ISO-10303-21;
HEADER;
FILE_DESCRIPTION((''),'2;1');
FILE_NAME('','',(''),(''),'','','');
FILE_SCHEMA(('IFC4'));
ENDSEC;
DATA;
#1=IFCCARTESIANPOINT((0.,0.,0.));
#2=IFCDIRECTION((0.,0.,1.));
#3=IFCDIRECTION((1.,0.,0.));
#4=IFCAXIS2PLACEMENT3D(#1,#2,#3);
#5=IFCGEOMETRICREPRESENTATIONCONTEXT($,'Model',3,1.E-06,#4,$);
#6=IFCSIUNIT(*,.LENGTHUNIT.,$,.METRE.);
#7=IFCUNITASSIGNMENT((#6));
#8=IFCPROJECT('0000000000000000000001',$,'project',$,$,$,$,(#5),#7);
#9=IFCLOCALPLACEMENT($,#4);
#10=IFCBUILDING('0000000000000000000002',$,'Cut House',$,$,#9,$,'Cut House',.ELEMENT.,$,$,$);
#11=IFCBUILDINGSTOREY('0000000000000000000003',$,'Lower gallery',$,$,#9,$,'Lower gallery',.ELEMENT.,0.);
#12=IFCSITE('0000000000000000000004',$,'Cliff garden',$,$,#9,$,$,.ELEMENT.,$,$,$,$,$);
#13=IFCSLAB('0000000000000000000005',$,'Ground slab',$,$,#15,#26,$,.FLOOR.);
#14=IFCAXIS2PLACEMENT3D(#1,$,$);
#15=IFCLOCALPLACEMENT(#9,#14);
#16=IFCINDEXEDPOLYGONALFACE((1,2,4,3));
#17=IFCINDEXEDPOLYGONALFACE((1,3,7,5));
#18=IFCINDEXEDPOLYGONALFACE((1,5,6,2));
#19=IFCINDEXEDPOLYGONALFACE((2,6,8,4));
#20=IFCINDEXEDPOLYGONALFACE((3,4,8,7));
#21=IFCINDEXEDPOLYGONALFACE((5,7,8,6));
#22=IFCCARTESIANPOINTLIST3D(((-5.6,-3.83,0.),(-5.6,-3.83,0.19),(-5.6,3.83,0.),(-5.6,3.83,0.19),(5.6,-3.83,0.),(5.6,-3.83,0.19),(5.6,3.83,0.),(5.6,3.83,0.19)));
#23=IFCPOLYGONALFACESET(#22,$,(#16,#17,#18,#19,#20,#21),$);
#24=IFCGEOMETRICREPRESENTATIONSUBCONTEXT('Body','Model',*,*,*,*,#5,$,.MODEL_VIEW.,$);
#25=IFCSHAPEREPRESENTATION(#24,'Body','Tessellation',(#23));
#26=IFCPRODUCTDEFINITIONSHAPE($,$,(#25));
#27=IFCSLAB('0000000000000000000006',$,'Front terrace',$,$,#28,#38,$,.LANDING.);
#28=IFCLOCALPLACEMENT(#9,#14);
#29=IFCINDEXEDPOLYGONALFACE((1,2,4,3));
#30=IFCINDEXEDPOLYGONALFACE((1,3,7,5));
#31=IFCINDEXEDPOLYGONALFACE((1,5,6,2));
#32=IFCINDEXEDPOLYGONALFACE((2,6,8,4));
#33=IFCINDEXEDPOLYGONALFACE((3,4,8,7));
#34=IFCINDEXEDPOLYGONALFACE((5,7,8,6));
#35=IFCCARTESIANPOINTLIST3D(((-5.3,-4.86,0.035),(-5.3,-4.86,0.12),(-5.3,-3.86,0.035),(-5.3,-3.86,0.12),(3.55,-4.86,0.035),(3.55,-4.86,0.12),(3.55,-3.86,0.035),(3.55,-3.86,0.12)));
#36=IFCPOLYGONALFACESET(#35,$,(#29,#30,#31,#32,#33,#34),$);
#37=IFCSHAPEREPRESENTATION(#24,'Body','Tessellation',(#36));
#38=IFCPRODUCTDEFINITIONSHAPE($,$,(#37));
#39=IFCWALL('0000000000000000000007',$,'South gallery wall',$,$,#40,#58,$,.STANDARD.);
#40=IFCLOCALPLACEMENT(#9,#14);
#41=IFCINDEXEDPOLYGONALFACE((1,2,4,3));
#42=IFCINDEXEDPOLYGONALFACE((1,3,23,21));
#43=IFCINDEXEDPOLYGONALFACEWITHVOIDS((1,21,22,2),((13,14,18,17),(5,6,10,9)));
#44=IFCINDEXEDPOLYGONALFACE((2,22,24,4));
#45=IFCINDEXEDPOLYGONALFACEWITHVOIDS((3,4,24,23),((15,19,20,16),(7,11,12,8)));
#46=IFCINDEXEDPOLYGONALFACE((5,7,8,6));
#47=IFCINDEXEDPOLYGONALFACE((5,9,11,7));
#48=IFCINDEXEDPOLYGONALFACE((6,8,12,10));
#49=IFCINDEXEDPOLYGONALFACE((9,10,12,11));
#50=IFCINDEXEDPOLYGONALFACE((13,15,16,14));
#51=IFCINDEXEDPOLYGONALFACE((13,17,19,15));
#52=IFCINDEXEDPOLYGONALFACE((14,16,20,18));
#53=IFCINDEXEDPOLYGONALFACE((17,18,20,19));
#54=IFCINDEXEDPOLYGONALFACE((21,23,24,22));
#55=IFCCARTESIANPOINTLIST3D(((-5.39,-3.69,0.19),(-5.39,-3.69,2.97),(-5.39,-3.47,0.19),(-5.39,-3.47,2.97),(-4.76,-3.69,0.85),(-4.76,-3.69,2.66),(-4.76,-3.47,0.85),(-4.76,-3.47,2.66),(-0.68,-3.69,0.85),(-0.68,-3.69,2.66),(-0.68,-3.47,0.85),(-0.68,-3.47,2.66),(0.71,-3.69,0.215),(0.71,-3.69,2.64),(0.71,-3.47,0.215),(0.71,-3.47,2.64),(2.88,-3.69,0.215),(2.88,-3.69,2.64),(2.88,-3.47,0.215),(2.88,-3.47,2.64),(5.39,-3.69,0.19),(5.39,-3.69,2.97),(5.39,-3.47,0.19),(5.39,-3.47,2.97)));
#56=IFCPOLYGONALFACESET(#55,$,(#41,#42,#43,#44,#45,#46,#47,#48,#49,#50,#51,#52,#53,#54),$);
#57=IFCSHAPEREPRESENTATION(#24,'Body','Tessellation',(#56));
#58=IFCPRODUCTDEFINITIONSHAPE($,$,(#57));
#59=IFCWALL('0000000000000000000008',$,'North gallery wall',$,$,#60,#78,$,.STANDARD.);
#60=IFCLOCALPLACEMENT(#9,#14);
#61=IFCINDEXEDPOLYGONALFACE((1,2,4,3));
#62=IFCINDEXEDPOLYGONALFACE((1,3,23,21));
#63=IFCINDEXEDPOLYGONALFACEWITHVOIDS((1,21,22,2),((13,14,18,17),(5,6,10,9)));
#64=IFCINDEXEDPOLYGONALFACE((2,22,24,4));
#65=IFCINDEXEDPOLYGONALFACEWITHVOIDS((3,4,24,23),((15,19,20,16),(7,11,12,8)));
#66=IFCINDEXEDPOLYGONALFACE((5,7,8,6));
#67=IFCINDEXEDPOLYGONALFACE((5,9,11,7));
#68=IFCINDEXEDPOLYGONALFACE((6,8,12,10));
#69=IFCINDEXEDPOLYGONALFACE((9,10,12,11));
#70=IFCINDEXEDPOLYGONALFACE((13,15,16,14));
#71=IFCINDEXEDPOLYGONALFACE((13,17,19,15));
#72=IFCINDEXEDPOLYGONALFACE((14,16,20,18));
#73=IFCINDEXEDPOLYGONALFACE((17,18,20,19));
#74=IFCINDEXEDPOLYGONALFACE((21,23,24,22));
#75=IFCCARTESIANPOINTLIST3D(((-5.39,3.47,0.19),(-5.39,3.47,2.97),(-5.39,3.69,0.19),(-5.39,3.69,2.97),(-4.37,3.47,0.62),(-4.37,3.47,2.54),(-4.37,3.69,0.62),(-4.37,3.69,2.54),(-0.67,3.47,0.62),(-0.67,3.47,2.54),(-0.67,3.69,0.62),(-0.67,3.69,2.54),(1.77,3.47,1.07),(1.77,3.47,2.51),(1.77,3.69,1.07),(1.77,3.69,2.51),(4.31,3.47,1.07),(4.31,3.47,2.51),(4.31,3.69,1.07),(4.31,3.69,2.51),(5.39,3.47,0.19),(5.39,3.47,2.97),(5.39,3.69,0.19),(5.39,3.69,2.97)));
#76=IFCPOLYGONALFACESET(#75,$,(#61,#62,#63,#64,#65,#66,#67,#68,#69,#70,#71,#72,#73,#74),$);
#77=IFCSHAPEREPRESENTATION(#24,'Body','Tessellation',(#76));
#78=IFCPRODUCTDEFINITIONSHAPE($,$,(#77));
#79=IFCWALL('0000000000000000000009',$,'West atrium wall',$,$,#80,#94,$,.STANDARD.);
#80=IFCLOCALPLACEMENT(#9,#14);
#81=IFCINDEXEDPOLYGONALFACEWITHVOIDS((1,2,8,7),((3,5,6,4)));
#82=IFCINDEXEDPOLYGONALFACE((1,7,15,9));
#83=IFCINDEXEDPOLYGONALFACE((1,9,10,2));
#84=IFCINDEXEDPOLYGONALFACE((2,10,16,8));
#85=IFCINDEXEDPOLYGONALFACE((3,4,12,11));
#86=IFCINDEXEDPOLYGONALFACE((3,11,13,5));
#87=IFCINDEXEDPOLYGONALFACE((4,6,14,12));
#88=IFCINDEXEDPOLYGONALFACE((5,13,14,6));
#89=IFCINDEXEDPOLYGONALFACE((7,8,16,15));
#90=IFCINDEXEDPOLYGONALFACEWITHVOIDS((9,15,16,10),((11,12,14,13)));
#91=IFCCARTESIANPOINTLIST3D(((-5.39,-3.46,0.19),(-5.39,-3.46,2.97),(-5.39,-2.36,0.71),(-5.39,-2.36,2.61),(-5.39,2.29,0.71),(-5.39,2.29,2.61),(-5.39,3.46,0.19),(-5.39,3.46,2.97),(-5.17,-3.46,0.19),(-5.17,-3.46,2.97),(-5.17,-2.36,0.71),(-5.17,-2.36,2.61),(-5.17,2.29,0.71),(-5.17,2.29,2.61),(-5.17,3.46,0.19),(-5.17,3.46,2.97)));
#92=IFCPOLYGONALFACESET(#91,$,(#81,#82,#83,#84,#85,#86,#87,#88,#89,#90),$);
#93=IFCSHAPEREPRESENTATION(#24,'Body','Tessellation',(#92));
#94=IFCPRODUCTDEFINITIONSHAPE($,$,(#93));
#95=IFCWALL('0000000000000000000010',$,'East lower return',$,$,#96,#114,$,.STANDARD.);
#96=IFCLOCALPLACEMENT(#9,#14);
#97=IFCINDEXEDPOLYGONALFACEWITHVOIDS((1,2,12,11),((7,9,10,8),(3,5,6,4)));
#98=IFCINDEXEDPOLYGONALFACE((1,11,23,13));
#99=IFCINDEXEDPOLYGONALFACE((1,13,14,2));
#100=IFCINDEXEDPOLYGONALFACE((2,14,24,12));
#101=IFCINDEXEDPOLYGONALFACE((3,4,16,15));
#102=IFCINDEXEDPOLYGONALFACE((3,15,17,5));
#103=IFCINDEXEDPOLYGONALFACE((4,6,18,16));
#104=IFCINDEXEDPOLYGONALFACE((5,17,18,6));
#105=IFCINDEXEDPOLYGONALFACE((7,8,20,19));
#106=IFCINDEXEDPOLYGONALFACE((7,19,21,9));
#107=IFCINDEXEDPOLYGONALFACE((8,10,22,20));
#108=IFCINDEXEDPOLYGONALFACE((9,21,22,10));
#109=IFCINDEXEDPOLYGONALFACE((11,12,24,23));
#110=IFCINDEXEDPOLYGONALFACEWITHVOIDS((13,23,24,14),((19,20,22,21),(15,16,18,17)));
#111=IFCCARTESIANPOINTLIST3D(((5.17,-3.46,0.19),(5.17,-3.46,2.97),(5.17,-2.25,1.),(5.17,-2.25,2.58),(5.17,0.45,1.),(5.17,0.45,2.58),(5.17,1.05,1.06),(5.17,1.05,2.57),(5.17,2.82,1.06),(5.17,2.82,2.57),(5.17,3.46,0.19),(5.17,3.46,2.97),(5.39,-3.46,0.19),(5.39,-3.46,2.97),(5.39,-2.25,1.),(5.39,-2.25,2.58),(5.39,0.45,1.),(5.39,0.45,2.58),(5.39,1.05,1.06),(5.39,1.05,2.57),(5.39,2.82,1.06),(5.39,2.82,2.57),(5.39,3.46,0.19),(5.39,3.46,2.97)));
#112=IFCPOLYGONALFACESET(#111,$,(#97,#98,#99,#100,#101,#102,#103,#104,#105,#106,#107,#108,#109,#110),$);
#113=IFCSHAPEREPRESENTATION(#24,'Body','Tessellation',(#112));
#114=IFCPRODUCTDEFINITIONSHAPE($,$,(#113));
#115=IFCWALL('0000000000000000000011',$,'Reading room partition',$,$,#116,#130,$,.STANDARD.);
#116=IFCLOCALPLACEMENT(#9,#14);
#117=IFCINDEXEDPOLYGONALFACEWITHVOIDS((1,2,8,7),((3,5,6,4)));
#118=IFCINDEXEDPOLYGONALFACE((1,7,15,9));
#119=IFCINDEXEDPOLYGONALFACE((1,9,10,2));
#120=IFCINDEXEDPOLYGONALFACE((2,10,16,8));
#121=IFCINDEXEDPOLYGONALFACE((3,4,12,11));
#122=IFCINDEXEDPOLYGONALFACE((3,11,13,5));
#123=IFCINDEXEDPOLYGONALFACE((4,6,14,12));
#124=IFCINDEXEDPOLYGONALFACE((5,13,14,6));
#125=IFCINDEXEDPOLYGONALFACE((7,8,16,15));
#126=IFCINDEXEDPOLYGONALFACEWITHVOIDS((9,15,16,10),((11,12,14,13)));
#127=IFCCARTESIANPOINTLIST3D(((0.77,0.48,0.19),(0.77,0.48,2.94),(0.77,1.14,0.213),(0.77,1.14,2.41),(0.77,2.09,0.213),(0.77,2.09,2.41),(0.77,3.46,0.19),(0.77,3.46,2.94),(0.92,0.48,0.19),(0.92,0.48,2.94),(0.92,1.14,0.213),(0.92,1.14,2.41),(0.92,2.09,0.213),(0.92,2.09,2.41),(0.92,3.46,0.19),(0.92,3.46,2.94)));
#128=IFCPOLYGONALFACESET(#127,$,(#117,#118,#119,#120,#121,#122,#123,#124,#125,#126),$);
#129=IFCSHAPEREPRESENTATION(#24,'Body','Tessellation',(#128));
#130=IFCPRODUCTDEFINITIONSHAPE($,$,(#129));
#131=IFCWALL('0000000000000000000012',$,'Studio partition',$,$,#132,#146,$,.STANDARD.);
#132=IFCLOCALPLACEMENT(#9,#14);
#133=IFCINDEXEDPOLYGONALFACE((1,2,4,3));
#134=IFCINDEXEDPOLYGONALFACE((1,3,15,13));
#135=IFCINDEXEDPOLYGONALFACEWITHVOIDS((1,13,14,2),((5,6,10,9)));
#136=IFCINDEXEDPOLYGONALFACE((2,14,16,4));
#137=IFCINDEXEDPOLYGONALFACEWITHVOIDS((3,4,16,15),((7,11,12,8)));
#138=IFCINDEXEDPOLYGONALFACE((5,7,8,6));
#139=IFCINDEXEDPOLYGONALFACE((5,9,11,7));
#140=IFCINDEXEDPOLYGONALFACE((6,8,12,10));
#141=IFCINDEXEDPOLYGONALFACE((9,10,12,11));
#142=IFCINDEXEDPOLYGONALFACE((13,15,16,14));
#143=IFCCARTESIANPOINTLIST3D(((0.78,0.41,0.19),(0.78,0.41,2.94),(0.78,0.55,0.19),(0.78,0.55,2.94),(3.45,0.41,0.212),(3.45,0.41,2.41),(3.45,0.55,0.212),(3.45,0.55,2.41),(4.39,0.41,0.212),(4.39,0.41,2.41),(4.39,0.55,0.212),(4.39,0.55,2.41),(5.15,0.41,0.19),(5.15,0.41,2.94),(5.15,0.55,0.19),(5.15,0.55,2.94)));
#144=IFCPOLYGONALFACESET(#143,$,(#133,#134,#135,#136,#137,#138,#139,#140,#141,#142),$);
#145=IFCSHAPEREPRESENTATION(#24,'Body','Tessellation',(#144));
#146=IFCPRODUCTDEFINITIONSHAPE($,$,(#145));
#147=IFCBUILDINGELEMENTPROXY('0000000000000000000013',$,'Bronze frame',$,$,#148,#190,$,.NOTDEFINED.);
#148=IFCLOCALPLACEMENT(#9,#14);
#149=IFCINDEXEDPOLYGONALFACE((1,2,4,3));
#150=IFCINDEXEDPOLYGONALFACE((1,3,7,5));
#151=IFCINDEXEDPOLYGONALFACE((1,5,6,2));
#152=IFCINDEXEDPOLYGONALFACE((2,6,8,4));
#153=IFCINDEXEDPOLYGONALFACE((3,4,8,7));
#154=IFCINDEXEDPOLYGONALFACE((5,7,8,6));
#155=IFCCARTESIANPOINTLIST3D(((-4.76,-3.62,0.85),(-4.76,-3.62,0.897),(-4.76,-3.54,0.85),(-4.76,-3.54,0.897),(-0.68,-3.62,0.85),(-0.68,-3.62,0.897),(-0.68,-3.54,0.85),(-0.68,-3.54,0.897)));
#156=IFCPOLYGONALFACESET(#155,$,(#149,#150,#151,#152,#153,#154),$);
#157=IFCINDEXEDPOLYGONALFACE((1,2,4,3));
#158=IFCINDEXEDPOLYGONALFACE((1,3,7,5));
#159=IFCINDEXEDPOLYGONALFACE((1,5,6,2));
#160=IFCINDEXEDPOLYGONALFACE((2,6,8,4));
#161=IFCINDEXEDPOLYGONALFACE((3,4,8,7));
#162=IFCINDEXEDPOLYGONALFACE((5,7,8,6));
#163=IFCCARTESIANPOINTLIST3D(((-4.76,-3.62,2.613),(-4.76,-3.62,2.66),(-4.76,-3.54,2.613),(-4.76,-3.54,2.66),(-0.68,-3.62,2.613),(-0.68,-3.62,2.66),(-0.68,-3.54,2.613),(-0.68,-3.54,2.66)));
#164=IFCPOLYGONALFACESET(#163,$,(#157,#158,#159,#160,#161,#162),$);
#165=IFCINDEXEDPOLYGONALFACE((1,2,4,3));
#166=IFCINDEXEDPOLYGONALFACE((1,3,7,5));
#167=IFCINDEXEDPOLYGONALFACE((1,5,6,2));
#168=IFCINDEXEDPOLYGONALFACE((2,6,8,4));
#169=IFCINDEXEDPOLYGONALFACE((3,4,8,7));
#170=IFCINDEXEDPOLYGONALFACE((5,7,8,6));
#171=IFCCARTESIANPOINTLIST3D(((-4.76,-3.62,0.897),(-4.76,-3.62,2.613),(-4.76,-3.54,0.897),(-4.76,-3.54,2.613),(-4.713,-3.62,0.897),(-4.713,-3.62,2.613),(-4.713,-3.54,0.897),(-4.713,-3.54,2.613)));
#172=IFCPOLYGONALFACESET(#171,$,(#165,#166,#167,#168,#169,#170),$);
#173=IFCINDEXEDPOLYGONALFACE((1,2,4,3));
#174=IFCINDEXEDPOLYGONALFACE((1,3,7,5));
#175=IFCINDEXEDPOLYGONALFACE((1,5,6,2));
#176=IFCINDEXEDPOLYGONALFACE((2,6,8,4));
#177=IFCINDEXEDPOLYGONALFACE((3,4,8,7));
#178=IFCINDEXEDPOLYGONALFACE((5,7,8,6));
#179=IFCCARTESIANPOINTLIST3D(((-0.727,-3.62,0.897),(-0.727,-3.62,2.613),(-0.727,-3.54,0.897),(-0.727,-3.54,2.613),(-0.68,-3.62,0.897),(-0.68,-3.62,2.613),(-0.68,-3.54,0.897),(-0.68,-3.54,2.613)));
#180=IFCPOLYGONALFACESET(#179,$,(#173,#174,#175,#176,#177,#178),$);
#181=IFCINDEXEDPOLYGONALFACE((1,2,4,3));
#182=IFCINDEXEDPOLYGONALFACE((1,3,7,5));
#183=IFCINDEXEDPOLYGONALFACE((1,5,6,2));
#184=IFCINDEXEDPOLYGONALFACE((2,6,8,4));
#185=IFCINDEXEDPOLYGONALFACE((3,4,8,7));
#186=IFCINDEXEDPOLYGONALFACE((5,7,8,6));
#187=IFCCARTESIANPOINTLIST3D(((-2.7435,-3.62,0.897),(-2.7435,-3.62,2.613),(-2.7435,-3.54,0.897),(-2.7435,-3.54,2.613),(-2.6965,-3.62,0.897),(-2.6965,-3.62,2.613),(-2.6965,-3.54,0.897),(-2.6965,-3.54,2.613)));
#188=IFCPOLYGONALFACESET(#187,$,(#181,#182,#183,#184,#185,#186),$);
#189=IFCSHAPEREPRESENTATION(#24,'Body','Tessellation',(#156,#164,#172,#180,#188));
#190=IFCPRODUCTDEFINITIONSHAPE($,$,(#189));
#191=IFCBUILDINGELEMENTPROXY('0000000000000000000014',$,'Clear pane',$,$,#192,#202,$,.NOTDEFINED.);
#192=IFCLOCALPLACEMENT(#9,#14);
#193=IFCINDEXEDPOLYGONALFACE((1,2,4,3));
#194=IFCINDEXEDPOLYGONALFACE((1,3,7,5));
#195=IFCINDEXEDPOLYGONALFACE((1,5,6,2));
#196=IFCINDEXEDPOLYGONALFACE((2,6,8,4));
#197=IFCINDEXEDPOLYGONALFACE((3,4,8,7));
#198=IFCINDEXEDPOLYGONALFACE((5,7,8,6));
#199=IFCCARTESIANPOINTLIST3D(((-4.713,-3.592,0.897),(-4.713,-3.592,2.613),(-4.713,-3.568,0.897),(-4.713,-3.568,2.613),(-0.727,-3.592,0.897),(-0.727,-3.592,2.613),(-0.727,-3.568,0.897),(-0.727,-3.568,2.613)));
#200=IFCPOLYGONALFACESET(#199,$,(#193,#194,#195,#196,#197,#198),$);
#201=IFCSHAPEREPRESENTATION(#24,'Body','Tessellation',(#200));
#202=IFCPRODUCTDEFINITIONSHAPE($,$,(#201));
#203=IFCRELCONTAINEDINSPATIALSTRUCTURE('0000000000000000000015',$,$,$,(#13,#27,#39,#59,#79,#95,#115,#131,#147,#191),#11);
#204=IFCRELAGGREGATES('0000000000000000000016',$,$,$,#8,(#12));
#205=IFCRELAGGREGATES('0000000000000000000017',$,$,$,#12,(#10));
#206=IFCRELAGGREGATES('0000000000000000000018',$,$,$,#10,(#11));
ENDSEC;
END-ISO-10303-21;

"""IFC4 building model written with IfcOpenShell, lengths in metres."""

from ifc_helpers import new_model, si_unit, frame, origin_with_axes, place, context, subcontext, project, spatial, polyline, outline, extrude, element, save


model = new_model("IFC4")

# Units and contexts
model_context = context("Model", 3, precision=1e-06, world=origin_with_axes())
body_context = subcontext(model_context, "Body", "Model", "MODEL_VIEW")
ifc_project = project(units=[si_unit("LENGTHUNIT", "METRE")], contexts=[model_context])

# Site, building, storey
placement = place(None, origin_with_axes())
site = spatial("IfcSite", under=ifc_project, at=placement, Name="Cliff garden", CompositionType="ELEMENT")
building = spatial("IfcBuilding", under=site, at=placement, Name="Cut House", LongName="Cut House", CompositionType="ELEMENT")
storey = spatial("IfcBuildingStorey", under=building, at=placement, Name="Lower gallery", LongName="Lower gallery", CompositionType="ELEMENT", Elevation=0.0)

# Slabs
element("IfcSlab", 1, at=placement, inside=storey, Name="Ground slab", PredefinedType="FLOOR", context=body_context, shape_type="SweptSolid", body=[
    extrude(outline(polyline([(0.0, 0.0), (11.2, 0.0), (11.2, 7.66), (0.0, 7.66), (0.0, 0.0)])), frame((-5.6, -3.83, 0.0), z_axis=(0.0, 0.0, 1.0), x_axis=(1.0, 0.0, 0.0)), (0.0, 0.0, 1.0), 0.19),
])
element("IfcSlab", 2, at=placement, inside=storey, Name="Front terrace", PredefinedType="LANDING", context=body_context, shape_type="SweptSolid", body=[
    extrude(outline(polyline([(0.0, 0.0), (8.85, 0.0), (8.85, 1.0), (0.0, 1.0), (0.0, 0.0)])), frame((-5.3, -4.86, 0.035), z_axis=(0.0, 0.0, 1.0), x_axis=(1.0, 0.0, 0.0)), (0.0, 0.0, 1.0), 0.085),
])

# Walls
element("IfcWall", 3, at=placement, inside=storey, Name="South gallery wall", PredefinedType="STANDARD", context=body_context, shape_type="SweptSolid", body=[
    extrude(outline(polyline([(0.0, 0.0), (10.78, 0.0), (10.78, 2.78), (0.0, 2.78), (0.0, 0.0)]), holes=[polyline([(0.63, 0.66), (4.71, 0.66), (4.71, 2.47), (0.63, 2.47), (0.63, 0.66)]), polyline([(6.1, 0.025), (8.27, 0.025), (8.27, 2.45), (6.1, 2.45), (6.1, 0.025)])]), frame((-5.39, -3.47, 0.19), z_axis=(0.0, -1.0, 0.0), x_axis=(1.0, 0.0, 0.0)), (0.0, 0.0, 1.0), 0.22),
])
element("IfcWall", 4, at=placement, inside=storey, Name="North gallery wall", PredefinedType="STANDARD", context=body_context, shape_type="SweptSolid", body=[
    extrude(outline(polyline([(0.0, 0.0), (10.78, 0.0), (10.78, 2.78), (0.0, 2.78), (0.0, 0.0)]), holes=[polyline([(1.02, 0.43), (4.72, 0.43), (4.72, 2.35), (1.02, 2.35), (1.02, 0.43)]), polyline([(7.16, 0.88), (9.7, 0.88), (9.7, 2.32), (7.16, 2.32), (7.16, 0.88)])]), frame((-5.39, 3.69, 0.19), z_axis=(0.0, -1.0, 0.0), x_axis=(1.0, 0.0, 0.0)), (0.0, 0.0, 1.0), 0.22),
])
element("IfcWall", 5, at=placement, inside=storey, Name="West atrium wall", PredefinedType="STANDARD", context=body_context, shape_type="SweptSolid", body=[
    extrude(outline(polyline([(0.0, 0.0), (6.92, 0.0), (6.92, 2.78), (0.0, 2.78), (0.0, 0.0)]), holes=[polyline([(1.1, 0.52), (5.75, 0.52), (5.75, 2.42), (1.1, 2.42), (1.1, 0.52)])]), frame((-5.39, -3.46, 0.19), z_axis=(1.0, 0.0, 0.0), x_axis=(0.0, 1.0, 0.0)), (0.0, 0.0, 1.0), 0.22),
])
element("IfcWall", 6, at=placement, inside=storey, Name="East lower return", PredefinedType="STANDARD", context=body_context, shape_type="SweptSolid", body=[
    extrude(outline(polyline([(0.0, 0.0), (6.92, 0.0), (6.92, 2.78), (0.0, 2.78), (0.0, 0.0)]), holes=[polyline([(1.21, 0.81), (3.91, 0.81), (3.91, 2.39), (1.21, 2.39), (1.21, 0.81)]), polyline([(4.51, 0.87), (6.28, 0.87), (6.28, 2.38), (4.51, 2.38), (4.51, 0.87)])]), frame((5.17, -3.46, 0.19), z_axis=(1.0, 0.0, 0.0), x_axis=(0.0, 1.0, 0.0)), (0.0, 0.0, 1.0), 0.22),
])
element("IfcWall", 7, at=placement, inside=storey, Name="Reading room partition", PredefinedType="STANDARD", context=body_context, shape_type="SweptSolid", body=[
    extrude(outline(polyline([(0.0, 0.0), (2.98, 0.0), (2.98, 2.75), (0.0, 2.75), (0.0, 0.0)]), holes=[polyline([(0.66, 0.023), (1.61, 0.023), (1.61, 2.22), (0.66, 2.22), (0.66, 0.023)])]), frame((0.77, 0.48, 0.19), z_axis=(1.0, 0.0, 0.0), x_axis=(0.0, 1.0, 0.0)), (0.0, 0.0, 1.0), 0.15),
])
element("IfcWall", 8, at=placement, inside=storey, Name="Studio partition", PredefinedType="STANDARD", context=body_context, shape_type="SweptSolid", body=[
    extrude(outline(polyline([(0.0, 0.0), (4.37, 0.0), (4.37, 2.75), (0.0, 2.75), (0.0, 0.0)]), holes=[polyline([(2.67, 0.022), (3.61, 0.022), (3.61, 2.22), (2.67, 2.22), (2.67, 0.022)])]), frame((0.78, 0.55, 0.19), z_axis=(0.0, -1.0, 0.0), x_axis=(1.0, 0.0, 0.0)), (0.0, 0.0, 1.0), 0.14),
])

# Building element proxies
element("IfcBuildingElementProxy", 9, at=placement, inside=storey, Name="Bronze frame", PredefinedType="NOTDEFINED", context=body_context, shape_type="SweptSolid", body=[
    extrude(outline(polyline([(0.0, 0.0), (4.08, 0.0), (4.08, 0.08), (0.0, 0.08), (0.0, 0.0)])), frame((-4.76, -3.62, 0.85), z_axis=(0.0, 0.0, 1.0), x_axis=(1.0, 0.0, 0.0)), (0.0, 0.0, 1.0), 0.047),
    extrude(outline(polyline([(0.0, 0.0), (4.08, 0.0), (4.08, 0.08), (0.0, 0.08), (0.0, 0.0)])), frame((-4.76, -3.62, 2.613), z_axis=(0.0, 0.0, 1.0), x_axis=(1.0, 0.0, 0.0)), (0.0, 0.0, 1.0), 0.047),
    extrude(outline(polyline([(0.0, 0.0), (0.047, 0.0), (0.047, 0.08), (0.0, 0.08), (0.0, 0.0)])), frame((-4.76, -3.62, 0.897), z_axis=(0.0, 0.0, 1.0), x_axis=(1.0, 0.0, 0.0)), (0.0, 0.0, 1.0), 1.716),
    extrude(outline(polyline([(0.0, 0.0), (0.047, 0.0), (0.047, 0.08), (0.0, 0.08), (0.0, 0.0)])), frame((-0.727, -3.62, 0.897), z_axis=(0.0, 0.0, 1.0), x_axis=(1.0, 0.0, 0.0)), (0.0, 0.0, 1.0), 1.716),
    extrude(outline(polyline([(0.0, 0.0), (0.047, 0.0), (0.047, 0.08), (0.0, 0.08), (0.0, 0.0)])), frame((-2.7435, -3.62, 0.897), z_axis=(0.0, 0.0, 1.0), x_axis=(1.0, 0.0, 0.0)), (0.0, 0.0, 1.0), 1.716),
])
element("IfcBuildingElementProxy", 10, at=placement, inside=storey, Name="Clear pane", PredefinedType="NOTDEFINED", context=body_context, shape_type="SweptSolid", body=[
    extrude(outline(polyline([(0.0, 0.0), (3.986, 0.0), (3.986, 0.024), (0.0, 0.024), (0.0, 0.0)])), frame((-4.713, -3.592, 0.897), z_axis=(0.0, 0.0, 1.0), x_axis=(1.0, 0.0, 0.0)), (0.0, 0.0, 1.0), 1.716),
])

save(model, "model.ifc")
